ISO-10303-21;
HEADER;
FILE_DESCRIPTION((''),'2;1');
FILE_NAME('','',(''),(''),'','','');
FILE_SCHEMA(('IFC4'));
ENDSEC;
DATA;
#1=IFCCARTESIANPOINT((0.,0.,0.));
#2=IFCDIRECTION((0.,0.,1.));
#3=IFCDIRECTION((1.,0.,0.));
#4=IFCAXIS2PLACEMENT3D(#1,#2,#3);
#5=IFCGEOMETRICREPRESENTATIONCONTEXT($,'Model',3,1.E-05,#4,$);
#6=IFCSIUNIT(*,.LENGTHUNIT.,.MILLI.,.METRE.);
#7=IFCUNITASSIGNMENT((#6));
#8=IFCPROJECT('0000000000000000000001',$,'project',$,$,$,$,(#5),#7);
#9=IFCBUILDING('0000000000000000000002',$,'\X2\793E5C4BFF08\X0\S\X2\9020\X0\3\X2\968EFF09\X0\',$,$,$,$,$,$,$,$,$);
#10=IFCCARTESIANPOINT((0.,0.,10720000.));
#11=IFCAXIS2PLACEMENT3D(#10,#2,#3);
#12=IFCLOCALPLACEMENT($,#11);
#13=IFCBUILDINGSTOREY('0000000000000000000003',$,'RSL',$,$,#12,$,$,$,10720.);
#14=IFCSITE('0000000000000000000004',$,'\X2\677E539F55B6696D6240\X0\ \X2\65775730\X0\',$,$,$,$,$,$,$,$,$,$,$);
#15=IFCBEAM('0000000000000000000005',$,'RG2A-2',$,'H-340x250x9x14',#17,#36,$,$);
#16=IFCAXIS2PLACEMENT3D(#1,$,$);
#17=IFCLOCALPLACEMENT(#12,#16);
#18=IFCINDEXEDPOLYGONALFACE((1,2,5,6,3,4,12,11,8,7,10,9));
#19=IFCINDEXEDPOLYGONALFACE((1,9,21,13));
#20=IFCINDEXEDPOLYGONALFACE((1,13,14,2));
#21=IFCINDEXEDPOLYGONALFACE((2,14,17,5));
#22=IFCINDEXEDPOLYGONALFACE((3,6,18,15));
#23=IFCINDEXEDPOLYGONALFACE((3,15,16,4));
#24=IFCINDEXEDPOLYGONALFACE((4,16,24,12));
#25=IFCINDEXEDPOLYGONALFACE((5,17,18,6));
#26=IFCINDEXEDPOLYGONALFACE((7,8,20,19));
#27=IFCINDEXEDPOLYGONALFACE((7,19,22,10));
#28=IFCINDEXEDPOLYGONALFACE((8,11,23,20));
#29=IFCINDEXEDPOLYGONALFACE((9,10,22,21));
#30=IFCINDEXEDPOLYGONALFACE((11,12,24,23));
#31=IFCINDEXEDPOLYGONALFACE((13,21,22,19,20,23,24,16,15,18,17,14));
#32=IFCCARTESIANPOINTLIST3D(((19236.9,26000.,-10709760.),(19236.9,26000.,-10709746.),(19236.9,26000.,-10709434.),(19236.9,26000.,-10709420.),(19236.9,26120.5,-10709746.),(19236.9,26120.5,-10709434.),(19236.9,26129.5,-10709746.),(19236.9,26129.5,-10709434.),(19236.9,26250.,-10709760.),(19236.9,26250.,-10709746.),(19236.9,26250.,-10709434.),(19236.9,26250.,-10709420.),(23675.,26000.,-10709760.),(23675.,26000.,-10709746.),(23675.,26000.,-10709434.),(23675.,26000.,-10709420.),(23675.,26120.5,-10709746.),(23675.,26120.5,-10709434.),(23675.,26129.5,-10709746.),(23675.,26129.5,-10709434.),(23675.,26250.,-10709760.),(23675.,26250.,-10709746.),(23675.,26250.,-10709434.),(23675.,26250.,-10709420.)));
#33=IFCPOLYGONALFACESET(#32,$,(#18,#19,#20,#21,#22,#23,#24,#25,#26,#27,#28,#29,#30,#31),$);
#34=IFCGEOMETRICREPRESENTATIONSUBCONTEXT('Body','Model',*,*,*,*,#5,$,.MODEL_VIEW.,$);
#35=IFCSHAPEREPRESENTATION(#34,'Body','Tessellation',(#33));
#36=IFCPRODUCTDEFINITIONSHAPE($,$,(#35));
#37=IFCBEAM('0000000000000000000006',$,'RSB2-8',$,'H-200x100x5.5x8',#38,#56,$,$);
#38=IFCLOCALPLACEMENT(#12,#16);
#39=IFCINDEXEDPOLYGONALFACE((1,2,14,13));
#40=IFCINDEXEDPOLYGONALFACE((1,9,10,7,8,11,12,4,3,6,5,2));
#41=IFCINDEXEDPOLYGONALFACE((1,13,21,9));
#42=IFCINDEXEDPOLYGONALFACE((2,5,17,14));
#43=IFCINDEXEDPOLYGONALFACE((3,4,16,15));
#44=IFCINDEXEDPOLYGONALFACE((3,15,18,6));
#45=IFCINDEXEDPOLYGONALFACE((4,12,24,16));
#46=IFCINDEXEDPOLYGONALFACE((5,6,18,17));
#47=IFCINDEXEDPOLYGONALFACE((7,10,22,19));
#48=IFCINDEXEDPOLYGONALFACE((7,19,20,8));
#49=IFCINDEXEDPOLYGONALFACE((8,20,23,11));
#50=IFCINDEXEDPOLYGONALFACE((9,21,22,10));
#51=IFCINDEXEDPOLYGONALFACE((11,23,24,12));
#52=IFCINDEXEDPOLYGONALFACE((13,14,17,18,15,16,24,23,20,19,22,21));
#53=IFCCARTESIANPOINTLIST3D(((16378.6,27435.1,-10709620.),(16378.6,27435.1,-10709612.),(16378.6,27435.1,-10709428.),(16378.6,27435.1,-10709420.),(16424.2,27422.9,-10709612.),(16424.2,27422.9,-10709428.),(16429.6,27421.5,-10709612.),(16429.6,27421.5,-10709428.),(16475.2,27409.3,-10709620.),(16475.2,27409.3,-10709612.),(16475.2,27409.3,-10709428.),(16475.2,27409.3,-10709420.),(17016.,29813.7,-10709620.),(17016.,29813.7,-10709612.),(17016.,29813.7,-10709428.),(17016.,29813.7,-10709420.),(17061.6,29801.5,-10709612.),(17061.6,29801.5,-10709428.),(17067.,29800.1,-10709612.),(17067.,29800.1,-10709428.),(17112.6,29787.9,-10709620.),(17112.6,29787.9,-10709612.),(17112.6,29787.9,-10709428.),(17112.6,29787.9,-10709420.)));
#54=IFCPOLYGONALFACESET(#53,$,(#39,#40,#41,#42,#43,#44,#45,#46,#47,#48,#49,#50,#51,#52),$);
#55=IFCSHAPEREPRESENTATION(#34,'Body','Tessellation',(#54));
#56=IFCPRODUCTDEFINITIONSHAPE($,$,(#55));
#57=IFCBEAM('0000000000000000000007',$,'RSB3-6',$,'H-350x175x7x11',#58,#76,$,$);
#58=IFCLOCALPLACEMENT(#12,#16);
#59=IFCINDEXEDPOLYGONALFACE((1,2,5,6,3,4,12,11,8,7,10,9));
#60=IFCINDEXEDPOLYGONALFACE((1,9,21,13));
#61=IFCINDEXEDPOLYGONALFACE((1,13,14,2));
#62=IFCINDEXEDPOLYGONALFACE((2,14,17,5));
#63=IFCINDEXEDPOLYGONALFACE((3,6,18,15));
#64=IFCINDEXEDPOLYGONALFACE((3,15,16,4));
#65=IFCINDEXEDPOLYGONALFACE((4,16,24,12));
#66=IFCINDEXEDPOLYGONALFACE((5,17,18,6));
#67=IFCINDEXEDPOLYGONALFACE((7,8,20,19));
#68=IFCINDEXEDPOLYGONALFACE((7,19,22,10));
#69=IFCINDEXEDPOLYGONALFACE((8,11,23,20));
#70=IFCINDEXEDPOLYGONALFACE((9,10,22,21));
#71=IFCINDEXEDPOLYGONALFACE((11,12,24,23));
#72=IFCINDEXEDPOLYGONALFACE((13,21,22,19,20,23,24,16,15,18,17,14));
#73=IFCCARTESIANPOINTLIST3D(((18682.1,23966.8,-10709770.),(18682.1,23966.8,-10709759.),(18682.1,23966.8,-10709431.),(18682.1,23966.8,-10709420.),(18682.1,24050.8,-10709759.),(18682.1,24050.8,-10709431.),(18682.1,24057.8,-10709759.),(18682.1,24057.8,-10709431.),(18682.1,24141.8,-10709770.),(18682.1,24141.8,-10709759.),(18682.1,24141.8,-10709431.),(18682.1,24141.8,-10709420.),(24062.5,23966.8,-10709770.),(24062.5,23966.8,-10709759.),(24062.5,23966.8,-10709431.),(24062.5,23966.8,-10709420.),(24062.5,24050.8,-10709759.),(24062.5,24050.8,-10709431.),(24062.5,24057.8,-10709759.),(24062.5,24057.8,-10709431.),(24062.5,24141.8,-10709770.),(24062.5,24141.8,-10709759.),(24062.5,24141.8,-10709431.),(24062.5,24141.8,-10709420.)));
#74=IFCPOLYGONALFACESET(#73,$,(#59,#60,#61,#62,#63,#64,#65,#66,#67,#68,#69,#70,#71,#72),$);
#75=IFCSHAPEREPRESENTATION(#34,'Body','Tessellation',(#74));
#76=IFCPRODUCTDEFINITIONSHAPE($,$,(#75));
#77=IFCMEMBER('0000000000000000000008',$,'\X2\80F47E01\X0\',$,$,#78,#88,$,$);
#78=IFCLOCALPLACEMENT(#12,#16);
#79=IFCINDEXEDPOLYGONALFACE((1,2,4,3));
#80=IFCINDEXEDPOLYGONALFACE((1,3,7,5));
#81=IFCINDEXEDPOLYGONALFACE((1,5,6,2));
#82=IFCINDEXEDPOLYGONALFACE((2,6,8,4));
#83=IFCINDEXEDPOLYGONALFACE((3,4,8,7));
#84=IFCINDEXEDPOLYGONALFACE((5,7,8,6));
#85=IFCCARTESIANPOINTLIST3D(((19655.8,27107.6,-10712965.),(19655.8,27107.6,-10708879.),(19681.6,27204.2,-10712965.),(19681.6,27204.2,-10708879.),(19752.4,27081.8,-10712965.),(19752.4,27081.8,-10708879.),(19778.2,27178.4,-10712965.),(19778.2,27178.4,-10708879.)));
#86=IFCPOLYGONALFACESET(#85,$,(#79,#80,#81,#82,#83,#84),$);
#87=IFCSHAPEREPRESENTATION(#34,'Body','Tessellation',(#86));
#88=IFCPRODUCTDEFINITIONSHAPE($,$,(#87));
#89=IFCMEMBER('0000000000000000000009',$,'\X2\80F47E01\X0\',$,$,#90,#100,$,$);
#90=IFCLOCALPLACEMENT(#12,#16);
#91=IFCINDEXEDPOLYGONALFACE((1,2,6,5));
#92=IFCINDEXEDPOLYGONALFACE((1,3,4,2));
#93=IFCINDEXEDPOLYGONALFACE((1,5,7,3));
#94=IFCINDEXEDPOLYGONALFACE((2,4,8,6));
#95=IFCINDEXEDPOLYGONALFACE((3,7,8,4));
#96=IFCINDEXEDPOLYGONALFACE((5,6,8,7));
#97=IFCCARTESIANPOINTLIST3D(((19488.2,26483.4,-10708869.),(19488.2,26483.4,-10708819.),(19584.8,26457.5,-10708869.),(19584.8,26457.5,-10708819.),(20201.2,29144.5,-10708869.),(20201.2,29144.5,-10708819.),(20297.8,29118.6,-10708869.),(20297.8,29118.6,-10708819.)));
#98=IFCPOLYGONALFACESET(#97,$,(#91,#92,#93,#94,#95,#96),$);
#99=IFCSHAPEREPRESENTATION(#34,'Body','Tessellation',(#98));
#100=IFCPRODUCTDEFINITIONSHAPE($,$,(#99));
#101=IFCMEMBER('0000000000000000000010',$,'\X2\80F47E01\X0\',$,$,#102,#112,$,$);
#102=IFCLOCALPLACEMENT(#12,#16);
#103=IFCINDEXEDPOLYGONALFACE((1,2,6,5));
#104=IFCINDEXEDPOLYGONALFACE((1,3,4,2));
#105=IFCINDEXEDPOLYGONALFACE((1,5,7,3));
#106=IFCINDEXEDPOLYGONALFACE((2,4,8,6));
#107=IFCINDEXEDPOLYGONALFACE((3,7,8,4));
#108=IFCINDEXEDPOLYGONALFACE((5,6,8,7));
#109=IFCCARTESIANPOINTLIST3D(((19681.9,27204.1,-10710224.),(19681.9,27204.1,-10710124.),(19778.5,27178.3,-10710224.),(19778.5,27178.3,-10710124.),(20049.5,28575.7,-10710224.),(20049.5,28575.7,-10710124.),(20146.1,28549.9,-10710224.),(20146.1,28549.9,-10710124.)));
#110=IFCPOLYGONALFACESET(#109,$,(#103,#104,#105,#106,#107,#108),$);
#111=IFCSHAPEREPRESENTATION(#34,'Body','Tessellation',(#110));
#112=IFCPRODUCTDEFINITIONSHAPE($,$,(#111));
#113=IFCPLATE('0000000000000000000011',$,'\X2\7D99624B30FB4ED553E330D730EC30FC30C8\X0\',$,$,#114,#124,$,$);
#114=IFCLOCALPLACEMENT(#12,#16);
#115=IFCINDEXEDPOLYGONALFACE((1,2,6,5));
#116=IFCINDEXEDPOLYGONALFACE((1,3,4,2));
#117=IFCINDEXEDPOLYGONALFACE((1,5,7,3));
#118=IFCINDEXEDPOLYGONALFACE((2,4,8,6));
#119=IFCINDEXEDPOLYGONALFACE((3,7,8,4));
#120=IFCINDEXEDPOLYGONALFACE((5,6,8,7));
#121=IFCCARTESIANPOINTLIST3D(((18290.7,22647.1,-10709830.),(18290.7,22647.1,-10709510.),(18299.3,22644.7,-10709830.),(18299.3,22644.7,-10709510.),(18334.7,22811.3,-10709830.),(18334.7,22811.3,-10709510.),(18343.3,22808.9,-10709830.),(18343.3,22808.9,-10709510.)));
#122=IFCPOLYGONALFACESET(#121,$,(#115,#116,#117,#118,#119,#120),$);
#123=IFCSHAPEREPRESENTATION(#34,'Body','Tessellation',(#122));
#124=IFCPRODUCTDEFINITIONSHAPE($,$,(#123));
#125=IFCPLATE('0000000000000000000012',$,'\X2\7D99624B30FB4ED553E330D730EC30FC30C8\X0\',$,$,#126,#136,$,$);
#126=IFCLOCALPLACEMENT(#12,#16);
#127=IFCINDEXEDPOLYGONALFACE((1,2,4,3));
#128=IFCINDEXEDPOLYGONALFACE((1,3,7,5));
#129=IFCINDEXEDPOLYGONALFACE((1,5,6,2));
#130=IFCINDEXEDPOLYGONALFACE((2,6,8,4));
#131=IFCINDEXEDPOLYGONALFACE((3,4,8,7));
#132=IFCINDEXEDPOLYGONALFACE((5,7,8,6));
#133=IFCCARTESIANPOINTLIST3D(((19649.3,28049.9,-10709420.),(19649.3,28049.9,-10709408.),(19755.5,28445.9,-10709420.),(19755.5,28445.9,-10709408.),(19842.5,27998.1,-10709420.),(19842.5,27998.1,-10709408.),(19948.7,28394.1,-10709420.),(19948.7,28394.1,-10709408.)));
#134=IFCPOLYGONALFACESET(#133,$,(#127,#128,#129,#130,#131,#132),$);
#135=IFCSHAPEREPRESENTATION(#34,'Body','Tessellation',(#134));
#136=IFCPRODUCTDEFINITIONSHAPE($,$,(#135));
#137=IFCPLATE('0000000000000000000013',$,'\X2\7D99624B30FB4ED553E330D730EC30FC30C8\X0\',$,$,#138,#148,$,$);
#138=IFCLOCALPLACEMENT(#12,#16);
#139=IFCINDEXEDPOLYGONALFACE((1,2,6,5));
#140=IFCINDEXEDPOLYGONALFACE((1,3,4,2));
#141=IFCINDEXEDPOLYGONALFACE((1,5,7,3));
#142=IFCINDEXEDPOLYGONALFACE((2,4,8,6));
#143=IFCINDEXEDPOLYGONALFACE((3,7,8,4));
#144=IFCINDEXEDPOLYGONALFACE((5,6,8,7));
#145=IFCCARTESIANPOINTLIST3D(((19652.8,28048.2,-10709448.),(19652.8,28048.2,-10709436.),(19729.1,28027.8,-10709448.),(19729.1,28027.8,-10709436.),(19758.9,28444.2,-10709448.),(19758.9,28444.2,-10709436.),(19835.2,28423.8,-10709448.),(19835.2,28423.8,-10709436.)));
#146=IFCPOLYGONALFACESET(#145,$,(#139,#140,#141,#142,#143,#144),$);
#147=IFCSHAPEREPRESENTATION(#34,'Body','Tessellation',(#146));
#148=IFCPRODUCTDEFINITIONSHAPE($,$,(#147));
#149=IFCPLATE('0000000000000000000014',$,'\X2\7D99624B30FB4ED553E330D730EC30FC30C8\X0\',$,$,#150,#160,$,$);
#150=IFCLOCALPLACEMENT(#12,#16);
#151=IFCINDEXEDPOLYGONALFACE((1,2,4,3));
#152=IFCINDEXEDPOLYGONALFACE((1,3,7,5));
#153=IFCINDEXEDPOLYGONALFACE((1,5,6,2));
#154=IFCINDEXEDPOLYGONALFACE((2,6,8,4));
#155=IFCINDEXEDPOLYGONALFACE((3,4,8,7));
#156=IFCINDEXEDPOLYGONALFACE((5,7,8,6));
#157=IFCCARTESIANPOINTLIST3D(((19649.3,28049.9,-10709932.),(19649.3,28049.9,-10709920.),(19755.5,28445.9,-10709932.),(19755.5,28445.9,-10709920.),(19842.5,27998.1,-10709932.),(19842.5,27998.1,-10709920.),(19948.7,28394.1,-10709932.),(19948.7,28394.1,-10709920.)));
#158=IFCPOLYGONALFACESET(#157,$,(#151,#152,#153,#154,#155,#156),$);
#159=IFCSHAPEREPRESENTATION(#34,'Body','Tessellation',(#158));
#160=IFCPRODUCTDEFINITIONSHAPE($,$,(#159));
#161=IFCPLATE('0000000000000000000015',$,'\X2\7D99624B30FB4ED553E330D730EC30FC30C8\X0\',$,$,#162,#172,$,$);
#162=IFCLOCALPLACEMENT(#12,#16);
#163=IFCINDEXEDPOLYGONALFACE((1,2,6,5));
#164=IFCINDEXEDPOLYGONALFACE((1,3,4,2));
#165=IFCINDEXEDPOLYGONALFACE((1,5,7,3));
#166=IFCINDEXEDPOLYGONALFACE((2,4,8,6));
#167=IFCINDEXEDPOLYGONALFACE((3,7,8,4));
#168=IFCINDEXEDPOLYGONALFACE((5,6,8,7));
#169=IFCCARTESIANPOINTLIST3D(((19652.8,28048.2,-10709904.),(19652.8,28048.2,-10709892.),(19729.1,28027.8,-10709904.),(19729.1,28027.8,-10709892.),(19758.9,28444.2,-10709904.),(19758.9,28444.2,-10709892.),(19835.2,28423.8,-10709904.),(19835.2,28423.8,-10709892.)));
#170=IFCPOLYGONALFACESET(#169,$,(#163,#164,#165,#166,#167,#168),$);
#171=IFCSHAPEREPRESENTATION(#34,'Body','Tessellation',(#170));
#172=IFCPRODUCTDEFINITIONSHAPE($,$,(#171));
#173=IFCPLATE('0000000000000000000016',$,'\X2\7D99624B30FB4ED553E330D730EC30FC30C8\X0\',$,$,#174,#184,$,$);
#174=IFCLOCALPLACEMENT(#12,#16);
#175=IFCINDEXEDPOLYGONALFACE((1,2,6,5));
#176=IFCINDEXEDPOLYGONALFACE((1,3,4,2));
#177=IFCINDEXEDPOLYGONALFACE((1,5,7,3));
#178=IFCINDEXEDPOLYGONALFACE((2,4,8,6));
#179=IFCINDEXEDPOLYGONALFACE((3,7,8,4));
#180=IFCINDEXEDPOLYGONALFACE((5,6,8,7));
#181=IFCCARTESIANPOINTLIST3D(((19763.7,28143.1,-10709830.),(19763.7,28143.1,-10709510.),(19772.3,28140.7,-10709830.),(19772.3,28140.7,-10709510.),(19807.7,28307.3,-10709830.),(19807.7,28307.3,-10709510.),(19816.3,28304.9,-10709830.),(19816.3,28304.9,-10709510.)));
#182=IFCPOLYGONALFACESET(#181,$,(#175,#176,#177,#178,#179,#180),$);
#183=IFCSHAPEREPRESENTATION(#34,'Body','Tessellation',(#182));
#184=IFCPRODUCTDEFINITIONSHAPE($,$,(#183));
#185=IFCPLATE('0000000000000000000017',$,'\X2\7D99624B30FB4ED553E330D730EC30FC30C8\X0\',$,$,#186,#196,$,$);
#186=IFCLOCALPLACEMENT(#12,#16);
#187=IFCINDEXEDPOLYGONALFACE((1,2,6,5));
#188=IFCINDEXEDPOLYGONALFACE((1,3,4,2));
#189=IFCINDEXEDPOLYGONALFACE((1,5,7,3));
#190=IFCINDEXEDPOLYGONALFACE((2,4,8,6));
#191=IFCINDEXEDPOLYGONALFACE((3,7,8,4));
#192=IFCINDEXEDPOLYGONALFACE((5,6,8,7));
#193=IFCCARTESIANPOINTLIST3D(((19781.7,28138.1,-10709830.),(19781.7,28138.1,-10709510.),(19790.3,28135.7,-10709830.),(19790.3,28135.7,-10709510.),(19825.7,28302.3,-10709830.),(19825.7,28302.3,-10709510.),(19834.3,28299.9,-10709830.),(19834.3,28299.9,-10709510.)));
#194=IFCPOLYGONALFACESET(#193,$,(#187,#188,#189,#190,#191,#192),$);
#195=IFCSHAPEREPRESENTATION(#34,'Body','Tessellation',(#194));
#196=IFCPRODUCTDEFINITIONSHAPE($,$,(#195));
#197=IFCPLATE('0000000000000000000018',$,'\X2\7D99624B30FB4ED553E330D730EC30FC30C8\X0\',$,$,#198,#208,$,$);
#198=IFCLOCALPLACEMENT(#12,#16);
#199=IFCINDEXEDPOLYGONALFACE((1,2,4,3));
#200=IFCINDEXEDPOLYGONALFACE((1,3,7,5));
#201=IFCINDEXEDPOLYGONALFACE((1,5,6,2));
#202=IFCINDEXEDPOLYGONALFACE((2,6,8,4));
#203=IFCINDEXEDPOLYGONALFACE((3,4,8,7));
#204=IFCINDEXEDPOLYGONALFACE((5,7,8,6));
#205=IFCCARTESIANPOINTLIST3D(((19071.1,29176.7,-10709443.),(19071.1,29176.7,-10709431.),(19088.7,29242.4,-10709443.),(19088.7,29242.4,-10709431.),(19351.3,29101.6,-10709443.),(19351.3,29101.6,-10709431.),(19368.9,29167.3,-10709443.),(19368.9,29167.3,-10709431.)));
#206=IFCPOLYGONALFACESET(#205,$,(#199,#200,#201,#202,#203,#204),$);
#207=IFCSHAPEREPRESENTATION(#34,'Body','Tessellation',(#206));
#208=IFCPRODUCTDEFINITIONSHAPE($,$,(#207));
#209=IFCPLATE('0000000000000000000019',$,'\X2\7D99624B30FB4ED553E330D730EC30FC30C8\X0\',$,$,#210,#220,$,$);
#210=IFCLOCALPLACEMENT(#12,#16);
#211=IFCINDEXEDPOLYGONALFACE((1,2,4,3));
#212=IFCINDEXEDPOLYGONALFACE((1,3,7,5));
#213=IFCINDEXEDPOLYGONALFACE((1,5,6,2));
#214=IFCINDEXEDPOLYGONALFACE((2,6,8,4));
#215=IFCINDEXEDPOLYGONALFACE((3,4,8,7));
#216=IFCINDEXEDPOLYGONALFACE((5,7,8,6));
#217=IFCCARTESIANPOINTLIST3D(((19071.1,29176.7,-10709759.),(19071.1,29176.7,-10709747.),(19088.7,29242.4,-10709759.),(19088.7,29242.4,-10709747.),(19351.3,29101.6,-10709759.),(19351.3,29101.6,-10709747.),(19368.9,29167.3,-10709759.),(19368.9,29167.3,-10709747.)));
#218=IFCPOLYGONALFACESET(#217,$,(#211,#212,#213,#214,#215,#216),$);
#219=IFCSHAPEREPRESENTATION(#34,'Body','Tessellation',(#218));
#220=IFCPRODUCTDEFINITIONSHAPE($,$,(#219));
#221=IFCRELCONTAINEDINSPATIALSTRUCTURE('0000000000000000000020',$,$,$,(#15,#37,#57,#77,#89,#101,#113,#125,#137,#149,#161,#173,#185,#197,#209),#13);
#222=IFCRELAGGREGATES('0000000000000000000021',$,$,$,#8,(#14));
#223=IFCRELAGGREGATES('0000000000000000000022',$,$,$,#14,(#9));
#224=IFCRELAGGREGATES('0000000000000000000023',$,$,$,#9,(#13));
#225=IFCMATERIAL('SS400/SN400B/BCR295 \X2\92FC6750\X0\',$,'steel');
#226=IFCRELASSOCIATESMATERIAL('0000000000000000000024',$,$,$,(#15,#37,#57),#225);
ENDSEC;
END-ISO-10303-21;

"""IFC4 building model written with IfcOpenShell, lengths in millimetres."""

from ifc_helpers import new_model, si_unit, frame, origin, origin_with_axes, place, context, subcontext, project, spatial, rectangle, i_section, extrude, material, element, save


model = new_model("IFC4")

# Units and contexts
model_context = context("Model", 3, precision=1e-05, world=origin_with_axes())
body_context = subcontext(model_context, "Body", "Model", "MODEL_VIEW")
ifc_project = project(units=[si_unit("LENGTHUNIT", "METRE", prefix="MILLI")], contexts=[model_context])

# Site, building, storey
site = spatial("IfcSite", under=ifc_project, Name="松原営業所 敷地")
building = spatial("IfcBuilding", under=site, Name="社屋（S造3階）")
storey_placement = place(None, frame((0.0, 0.0, 10720000.0), z_axis=(0.0, 0.0, 1.0), x_axis=(1.0, 0.0, 0.0)))
storey = spatial("IfcBuildingStorey", under=building, at=storey_placement, Name="RSL", Elevation=10720.0)

# Beams
ifc_material = material(Name="SS400/SN400B/BCR295 鋼材", Category="steel")
beam_1_placement = place(storey_placement, frame((19236.9, 26125.0, -10709420.0), z_axis=(1.0, 0.0, 0.0), x_axis=(0.0, 1.0, 0.0)))
element("IfcBeam", 1, at=beam_1_placement, inside=storey, material=ifc_material, Name="RG2A-2", ObjectType="H-340x250x9x14", context=body_context, shape_type="SweptSolid", body=[
    extrude(i_section(OverallWidth=250.0, OverallDepth=340.0, WebThickness=9.0, FlangeThickness=14.0), frame((0.0, -170.0, 0.0)), (0.0, 0.0, 1.0), 4438.1),
])
beam_2_placement = place(storey_placement, frame((16426.9, 27422.2, -10709420.0), z_axis=(0.25884, 0.96592, 0.0), x_axis=(-0.96592, 0.25884, 0.0)))
element("IfcBeam", 2, at=beam_2_placement, inside=storey, material=ifc_material, Name="RSB2-8", ObjectType="H-200x100x5.5x8", context=body_context, shape_type="SweptSolid", body=[
    extrude(i_section(OverallWidth=100.0, OverallDepth=200.0, WebThickness=5.5, FlangeThickness=8.0), frame((0.0, -100.0, 0.0)), (0.0, 0.0, 1.0), 2462.5),
])
beam_3_placement = place(storey_placement, frame((18682.1, 24054.3, -10709420.0), z_axis=(1.0, 0.0, 0.0), x_axis=(0.0, 1.0, 0.0)))
element("IfcBeam", 3, at=beam_3_placement, inside=storey, material=ifc_material, Name="RSB3-6", ObjectType="H-350x175x7x11", context=body_context, shape_type="SweptSolid", body=[
    extrude(i_section(OverallWidth=175.0, OverallDepth=350.0, WebThickness=7.0, FlangeThickness=11.0), frame((0.0, -175.0, 0.0)), (0.0, 0.0, 1.0), 5380.4),
])

# Members
member_1_placement = place(storey_placement, frame((19704.1, 27094.7, -10710922.0), z_axis=(0.258819, 0.965926, 0.0), x_axis=(-0.965926, 0.258819, 0.0)))
element("IfcMember", 4, at=member_1_placement, inside=storey, Name="胴縁", context=body_context, shape_type="SweptSolid", body=[
    extrude(rectangle(XDim=100.0, YDim=4086.0), origin(), (0.0, 0.0, 1.0), 100.0),
])
member_2_placement = place(storey_placement, frame((19536.5, 26470.4, -10708844.0), z_axis=(0.258819, 0.965926, 0.0), x_axis=(-0.965926, 0.258819, 0.0)))
element("IfcMember", 5, at=member_2_placement, inside=storey, Name="胴縁", context=body_context, shape_type="SweptSolid", body=[
    extrude(rectangle(XDim=100.0, YDim=50.0), origin(), (0.0, 0.0, 1.0), 2755.0),
])
member_3_placement = place(storey_placement, frame((19730.2, 27191.2, -10710174.0), z_axis=(0.258819, 0.965926, 0.0), x_axis=(-0.965926, 0.258819, 0.0)))
element("IfcMember", 6, at=member_3_placement, inside=storey, Name="胴縁", context=body_context, shape_type="SweptSolid", body=[
    extrude(rectangle(XDim=100.0, YDim=100.0), origin(), (0.0, 0.0, 1.0), 1420.0),
])

# Plates
plate_1_placement = place(storey_placement, frame((18295.0, 22645.9, -10709670.0), z_axis=(0.258819, 0.965926, 0.0), x_axis=(-0.965926, 0.258819, 0.0)))
element("IfcPlate", 7, at=plate_1_placement, inside=storey, Name="継手・仕口プレート", context=body_context, shape_type="SweptSolid", body=[
    extrude(rectangle(XDim=9.0, YDim=320.0), origin(), (0.0, 0.0, 1.0), 170.0),
])
plate_2_placement = place(storey_placement, frame((19745.9, 28024.0, -10709414.0), z_axis=(0.258819, 0.965926, 0.0), x_axis=(-0.965926, 0.258819, 0.0)))
element("IfcPlate", 8, at=plate_2_placement, inside=storey, Name="継手・仕口プレート", context=body_context, shape_type="SweptSolid", body=[
    extrude(rectangle(XDim=200.0, YDim=12.0), origin(), (0.0, 0.0, 1.0), 410.0),
])
plate_3_placement = place(storey_placement, frame((19690.9, 28038.0, -10709442.0), z_axis=(0.258819, 0.965926, 0.0), x_axis=(-0.965926, 0.258819, 0.0)))
element("IfcPlate", 9, at=plate_3_placement, inside=storey, Name="継手・仕口プレート", context=body_context, shape_type="SweptSolid", body=[
    extrude(rectangle(XDim=79.0, YDim=12.0), origin(), (0.0, 0.0, 1.0), 410.0),
])
plate_4_placement = place(storey_placement, frame((19745.9, 28024.0, -10709926.0), z_axis=(0.258819, 0.965926, 0.0), x_axis=(-0.965926, 0.258819, 0.0)))
element("IfcPlate", 10, at=plate_4_placement, inside=storey, Name="継手・仕口プレート", context=body_context, shape_type="SweptSolid", body=[
    extrude(rectangle(XDim=200.0, YDim=12.0), origin(), (0.0, 0.0, 1.0), 410.0),
])
plate_5_placement = place(storey_placement, frame((19690.9, 28038.0, -10709898.0), z_axis=(0.258819, 0.965926, 0.0), x_axis=(-0.965926, 0.258819, 0.0)))
element("IfcPlate", 11, at=plate_5_placement, inside=storey, Name="継手・仕口プレート", context=body_context, shape_type="SweptSolid", body=[
    extrude(rectangle(XDim=79.0, YDim=12.0), origin(), (0.0, 0.0, 1.0), 410.0),
])
for number, where, z_axis, x_axis, name in (
    (12, (19768.0, 28141.9, -10709670.0), (0.258819, 0.965926, 0.0), (-0.965926, 0.258819, 0.0), "継手・仕口プレート"),
    (13, (19786.0, 28136.9, -10709670.0), (0.258819, 0.965926, 0.0), (-0.965926, 0.258819, 0.0), "継手・仕口プレート"),
):
    element("IfcPlate", number, at=place(storey_placement, frame(where, z_axis=z_axis, x_axis=x_axis)), inside=storey, Name=name, context=body_context, shape_type="SweptSolid", body=[
        extrude(rectangle(XDim=9.0, YDim=320.0), origin(), (0.0, 0.0, 1.0), 170.0),
    ])
for number, where, z_axis, x_axis, name in (
    (14, (19079.9, 29209.5, -10709437.0), (0.965926, -0.258819, 0.0), (0.258819, 0.965926, 0.0), "継手・仕口プレート"),
    (15, (19079.9, 29209.5, -10709753.0), (0.965926, -0.258819, 0.0), (0.258819, 0.965926, 0.0), "継手・仕口プレート"),
):
    element("IfcPlate", number, at=place(storey_placement, frame(where, z_axis=z_axis, x_axis=x_axis)), inside=storey, Name=name, context=body_context, shape_type="SweptSolid", body=[
        extrude(rectangle(XDim=68.0, YDim=12.0), origin(), (0.0, 0.0, 1.0), 290.0),
    ])

save(model, "model.ifc")
